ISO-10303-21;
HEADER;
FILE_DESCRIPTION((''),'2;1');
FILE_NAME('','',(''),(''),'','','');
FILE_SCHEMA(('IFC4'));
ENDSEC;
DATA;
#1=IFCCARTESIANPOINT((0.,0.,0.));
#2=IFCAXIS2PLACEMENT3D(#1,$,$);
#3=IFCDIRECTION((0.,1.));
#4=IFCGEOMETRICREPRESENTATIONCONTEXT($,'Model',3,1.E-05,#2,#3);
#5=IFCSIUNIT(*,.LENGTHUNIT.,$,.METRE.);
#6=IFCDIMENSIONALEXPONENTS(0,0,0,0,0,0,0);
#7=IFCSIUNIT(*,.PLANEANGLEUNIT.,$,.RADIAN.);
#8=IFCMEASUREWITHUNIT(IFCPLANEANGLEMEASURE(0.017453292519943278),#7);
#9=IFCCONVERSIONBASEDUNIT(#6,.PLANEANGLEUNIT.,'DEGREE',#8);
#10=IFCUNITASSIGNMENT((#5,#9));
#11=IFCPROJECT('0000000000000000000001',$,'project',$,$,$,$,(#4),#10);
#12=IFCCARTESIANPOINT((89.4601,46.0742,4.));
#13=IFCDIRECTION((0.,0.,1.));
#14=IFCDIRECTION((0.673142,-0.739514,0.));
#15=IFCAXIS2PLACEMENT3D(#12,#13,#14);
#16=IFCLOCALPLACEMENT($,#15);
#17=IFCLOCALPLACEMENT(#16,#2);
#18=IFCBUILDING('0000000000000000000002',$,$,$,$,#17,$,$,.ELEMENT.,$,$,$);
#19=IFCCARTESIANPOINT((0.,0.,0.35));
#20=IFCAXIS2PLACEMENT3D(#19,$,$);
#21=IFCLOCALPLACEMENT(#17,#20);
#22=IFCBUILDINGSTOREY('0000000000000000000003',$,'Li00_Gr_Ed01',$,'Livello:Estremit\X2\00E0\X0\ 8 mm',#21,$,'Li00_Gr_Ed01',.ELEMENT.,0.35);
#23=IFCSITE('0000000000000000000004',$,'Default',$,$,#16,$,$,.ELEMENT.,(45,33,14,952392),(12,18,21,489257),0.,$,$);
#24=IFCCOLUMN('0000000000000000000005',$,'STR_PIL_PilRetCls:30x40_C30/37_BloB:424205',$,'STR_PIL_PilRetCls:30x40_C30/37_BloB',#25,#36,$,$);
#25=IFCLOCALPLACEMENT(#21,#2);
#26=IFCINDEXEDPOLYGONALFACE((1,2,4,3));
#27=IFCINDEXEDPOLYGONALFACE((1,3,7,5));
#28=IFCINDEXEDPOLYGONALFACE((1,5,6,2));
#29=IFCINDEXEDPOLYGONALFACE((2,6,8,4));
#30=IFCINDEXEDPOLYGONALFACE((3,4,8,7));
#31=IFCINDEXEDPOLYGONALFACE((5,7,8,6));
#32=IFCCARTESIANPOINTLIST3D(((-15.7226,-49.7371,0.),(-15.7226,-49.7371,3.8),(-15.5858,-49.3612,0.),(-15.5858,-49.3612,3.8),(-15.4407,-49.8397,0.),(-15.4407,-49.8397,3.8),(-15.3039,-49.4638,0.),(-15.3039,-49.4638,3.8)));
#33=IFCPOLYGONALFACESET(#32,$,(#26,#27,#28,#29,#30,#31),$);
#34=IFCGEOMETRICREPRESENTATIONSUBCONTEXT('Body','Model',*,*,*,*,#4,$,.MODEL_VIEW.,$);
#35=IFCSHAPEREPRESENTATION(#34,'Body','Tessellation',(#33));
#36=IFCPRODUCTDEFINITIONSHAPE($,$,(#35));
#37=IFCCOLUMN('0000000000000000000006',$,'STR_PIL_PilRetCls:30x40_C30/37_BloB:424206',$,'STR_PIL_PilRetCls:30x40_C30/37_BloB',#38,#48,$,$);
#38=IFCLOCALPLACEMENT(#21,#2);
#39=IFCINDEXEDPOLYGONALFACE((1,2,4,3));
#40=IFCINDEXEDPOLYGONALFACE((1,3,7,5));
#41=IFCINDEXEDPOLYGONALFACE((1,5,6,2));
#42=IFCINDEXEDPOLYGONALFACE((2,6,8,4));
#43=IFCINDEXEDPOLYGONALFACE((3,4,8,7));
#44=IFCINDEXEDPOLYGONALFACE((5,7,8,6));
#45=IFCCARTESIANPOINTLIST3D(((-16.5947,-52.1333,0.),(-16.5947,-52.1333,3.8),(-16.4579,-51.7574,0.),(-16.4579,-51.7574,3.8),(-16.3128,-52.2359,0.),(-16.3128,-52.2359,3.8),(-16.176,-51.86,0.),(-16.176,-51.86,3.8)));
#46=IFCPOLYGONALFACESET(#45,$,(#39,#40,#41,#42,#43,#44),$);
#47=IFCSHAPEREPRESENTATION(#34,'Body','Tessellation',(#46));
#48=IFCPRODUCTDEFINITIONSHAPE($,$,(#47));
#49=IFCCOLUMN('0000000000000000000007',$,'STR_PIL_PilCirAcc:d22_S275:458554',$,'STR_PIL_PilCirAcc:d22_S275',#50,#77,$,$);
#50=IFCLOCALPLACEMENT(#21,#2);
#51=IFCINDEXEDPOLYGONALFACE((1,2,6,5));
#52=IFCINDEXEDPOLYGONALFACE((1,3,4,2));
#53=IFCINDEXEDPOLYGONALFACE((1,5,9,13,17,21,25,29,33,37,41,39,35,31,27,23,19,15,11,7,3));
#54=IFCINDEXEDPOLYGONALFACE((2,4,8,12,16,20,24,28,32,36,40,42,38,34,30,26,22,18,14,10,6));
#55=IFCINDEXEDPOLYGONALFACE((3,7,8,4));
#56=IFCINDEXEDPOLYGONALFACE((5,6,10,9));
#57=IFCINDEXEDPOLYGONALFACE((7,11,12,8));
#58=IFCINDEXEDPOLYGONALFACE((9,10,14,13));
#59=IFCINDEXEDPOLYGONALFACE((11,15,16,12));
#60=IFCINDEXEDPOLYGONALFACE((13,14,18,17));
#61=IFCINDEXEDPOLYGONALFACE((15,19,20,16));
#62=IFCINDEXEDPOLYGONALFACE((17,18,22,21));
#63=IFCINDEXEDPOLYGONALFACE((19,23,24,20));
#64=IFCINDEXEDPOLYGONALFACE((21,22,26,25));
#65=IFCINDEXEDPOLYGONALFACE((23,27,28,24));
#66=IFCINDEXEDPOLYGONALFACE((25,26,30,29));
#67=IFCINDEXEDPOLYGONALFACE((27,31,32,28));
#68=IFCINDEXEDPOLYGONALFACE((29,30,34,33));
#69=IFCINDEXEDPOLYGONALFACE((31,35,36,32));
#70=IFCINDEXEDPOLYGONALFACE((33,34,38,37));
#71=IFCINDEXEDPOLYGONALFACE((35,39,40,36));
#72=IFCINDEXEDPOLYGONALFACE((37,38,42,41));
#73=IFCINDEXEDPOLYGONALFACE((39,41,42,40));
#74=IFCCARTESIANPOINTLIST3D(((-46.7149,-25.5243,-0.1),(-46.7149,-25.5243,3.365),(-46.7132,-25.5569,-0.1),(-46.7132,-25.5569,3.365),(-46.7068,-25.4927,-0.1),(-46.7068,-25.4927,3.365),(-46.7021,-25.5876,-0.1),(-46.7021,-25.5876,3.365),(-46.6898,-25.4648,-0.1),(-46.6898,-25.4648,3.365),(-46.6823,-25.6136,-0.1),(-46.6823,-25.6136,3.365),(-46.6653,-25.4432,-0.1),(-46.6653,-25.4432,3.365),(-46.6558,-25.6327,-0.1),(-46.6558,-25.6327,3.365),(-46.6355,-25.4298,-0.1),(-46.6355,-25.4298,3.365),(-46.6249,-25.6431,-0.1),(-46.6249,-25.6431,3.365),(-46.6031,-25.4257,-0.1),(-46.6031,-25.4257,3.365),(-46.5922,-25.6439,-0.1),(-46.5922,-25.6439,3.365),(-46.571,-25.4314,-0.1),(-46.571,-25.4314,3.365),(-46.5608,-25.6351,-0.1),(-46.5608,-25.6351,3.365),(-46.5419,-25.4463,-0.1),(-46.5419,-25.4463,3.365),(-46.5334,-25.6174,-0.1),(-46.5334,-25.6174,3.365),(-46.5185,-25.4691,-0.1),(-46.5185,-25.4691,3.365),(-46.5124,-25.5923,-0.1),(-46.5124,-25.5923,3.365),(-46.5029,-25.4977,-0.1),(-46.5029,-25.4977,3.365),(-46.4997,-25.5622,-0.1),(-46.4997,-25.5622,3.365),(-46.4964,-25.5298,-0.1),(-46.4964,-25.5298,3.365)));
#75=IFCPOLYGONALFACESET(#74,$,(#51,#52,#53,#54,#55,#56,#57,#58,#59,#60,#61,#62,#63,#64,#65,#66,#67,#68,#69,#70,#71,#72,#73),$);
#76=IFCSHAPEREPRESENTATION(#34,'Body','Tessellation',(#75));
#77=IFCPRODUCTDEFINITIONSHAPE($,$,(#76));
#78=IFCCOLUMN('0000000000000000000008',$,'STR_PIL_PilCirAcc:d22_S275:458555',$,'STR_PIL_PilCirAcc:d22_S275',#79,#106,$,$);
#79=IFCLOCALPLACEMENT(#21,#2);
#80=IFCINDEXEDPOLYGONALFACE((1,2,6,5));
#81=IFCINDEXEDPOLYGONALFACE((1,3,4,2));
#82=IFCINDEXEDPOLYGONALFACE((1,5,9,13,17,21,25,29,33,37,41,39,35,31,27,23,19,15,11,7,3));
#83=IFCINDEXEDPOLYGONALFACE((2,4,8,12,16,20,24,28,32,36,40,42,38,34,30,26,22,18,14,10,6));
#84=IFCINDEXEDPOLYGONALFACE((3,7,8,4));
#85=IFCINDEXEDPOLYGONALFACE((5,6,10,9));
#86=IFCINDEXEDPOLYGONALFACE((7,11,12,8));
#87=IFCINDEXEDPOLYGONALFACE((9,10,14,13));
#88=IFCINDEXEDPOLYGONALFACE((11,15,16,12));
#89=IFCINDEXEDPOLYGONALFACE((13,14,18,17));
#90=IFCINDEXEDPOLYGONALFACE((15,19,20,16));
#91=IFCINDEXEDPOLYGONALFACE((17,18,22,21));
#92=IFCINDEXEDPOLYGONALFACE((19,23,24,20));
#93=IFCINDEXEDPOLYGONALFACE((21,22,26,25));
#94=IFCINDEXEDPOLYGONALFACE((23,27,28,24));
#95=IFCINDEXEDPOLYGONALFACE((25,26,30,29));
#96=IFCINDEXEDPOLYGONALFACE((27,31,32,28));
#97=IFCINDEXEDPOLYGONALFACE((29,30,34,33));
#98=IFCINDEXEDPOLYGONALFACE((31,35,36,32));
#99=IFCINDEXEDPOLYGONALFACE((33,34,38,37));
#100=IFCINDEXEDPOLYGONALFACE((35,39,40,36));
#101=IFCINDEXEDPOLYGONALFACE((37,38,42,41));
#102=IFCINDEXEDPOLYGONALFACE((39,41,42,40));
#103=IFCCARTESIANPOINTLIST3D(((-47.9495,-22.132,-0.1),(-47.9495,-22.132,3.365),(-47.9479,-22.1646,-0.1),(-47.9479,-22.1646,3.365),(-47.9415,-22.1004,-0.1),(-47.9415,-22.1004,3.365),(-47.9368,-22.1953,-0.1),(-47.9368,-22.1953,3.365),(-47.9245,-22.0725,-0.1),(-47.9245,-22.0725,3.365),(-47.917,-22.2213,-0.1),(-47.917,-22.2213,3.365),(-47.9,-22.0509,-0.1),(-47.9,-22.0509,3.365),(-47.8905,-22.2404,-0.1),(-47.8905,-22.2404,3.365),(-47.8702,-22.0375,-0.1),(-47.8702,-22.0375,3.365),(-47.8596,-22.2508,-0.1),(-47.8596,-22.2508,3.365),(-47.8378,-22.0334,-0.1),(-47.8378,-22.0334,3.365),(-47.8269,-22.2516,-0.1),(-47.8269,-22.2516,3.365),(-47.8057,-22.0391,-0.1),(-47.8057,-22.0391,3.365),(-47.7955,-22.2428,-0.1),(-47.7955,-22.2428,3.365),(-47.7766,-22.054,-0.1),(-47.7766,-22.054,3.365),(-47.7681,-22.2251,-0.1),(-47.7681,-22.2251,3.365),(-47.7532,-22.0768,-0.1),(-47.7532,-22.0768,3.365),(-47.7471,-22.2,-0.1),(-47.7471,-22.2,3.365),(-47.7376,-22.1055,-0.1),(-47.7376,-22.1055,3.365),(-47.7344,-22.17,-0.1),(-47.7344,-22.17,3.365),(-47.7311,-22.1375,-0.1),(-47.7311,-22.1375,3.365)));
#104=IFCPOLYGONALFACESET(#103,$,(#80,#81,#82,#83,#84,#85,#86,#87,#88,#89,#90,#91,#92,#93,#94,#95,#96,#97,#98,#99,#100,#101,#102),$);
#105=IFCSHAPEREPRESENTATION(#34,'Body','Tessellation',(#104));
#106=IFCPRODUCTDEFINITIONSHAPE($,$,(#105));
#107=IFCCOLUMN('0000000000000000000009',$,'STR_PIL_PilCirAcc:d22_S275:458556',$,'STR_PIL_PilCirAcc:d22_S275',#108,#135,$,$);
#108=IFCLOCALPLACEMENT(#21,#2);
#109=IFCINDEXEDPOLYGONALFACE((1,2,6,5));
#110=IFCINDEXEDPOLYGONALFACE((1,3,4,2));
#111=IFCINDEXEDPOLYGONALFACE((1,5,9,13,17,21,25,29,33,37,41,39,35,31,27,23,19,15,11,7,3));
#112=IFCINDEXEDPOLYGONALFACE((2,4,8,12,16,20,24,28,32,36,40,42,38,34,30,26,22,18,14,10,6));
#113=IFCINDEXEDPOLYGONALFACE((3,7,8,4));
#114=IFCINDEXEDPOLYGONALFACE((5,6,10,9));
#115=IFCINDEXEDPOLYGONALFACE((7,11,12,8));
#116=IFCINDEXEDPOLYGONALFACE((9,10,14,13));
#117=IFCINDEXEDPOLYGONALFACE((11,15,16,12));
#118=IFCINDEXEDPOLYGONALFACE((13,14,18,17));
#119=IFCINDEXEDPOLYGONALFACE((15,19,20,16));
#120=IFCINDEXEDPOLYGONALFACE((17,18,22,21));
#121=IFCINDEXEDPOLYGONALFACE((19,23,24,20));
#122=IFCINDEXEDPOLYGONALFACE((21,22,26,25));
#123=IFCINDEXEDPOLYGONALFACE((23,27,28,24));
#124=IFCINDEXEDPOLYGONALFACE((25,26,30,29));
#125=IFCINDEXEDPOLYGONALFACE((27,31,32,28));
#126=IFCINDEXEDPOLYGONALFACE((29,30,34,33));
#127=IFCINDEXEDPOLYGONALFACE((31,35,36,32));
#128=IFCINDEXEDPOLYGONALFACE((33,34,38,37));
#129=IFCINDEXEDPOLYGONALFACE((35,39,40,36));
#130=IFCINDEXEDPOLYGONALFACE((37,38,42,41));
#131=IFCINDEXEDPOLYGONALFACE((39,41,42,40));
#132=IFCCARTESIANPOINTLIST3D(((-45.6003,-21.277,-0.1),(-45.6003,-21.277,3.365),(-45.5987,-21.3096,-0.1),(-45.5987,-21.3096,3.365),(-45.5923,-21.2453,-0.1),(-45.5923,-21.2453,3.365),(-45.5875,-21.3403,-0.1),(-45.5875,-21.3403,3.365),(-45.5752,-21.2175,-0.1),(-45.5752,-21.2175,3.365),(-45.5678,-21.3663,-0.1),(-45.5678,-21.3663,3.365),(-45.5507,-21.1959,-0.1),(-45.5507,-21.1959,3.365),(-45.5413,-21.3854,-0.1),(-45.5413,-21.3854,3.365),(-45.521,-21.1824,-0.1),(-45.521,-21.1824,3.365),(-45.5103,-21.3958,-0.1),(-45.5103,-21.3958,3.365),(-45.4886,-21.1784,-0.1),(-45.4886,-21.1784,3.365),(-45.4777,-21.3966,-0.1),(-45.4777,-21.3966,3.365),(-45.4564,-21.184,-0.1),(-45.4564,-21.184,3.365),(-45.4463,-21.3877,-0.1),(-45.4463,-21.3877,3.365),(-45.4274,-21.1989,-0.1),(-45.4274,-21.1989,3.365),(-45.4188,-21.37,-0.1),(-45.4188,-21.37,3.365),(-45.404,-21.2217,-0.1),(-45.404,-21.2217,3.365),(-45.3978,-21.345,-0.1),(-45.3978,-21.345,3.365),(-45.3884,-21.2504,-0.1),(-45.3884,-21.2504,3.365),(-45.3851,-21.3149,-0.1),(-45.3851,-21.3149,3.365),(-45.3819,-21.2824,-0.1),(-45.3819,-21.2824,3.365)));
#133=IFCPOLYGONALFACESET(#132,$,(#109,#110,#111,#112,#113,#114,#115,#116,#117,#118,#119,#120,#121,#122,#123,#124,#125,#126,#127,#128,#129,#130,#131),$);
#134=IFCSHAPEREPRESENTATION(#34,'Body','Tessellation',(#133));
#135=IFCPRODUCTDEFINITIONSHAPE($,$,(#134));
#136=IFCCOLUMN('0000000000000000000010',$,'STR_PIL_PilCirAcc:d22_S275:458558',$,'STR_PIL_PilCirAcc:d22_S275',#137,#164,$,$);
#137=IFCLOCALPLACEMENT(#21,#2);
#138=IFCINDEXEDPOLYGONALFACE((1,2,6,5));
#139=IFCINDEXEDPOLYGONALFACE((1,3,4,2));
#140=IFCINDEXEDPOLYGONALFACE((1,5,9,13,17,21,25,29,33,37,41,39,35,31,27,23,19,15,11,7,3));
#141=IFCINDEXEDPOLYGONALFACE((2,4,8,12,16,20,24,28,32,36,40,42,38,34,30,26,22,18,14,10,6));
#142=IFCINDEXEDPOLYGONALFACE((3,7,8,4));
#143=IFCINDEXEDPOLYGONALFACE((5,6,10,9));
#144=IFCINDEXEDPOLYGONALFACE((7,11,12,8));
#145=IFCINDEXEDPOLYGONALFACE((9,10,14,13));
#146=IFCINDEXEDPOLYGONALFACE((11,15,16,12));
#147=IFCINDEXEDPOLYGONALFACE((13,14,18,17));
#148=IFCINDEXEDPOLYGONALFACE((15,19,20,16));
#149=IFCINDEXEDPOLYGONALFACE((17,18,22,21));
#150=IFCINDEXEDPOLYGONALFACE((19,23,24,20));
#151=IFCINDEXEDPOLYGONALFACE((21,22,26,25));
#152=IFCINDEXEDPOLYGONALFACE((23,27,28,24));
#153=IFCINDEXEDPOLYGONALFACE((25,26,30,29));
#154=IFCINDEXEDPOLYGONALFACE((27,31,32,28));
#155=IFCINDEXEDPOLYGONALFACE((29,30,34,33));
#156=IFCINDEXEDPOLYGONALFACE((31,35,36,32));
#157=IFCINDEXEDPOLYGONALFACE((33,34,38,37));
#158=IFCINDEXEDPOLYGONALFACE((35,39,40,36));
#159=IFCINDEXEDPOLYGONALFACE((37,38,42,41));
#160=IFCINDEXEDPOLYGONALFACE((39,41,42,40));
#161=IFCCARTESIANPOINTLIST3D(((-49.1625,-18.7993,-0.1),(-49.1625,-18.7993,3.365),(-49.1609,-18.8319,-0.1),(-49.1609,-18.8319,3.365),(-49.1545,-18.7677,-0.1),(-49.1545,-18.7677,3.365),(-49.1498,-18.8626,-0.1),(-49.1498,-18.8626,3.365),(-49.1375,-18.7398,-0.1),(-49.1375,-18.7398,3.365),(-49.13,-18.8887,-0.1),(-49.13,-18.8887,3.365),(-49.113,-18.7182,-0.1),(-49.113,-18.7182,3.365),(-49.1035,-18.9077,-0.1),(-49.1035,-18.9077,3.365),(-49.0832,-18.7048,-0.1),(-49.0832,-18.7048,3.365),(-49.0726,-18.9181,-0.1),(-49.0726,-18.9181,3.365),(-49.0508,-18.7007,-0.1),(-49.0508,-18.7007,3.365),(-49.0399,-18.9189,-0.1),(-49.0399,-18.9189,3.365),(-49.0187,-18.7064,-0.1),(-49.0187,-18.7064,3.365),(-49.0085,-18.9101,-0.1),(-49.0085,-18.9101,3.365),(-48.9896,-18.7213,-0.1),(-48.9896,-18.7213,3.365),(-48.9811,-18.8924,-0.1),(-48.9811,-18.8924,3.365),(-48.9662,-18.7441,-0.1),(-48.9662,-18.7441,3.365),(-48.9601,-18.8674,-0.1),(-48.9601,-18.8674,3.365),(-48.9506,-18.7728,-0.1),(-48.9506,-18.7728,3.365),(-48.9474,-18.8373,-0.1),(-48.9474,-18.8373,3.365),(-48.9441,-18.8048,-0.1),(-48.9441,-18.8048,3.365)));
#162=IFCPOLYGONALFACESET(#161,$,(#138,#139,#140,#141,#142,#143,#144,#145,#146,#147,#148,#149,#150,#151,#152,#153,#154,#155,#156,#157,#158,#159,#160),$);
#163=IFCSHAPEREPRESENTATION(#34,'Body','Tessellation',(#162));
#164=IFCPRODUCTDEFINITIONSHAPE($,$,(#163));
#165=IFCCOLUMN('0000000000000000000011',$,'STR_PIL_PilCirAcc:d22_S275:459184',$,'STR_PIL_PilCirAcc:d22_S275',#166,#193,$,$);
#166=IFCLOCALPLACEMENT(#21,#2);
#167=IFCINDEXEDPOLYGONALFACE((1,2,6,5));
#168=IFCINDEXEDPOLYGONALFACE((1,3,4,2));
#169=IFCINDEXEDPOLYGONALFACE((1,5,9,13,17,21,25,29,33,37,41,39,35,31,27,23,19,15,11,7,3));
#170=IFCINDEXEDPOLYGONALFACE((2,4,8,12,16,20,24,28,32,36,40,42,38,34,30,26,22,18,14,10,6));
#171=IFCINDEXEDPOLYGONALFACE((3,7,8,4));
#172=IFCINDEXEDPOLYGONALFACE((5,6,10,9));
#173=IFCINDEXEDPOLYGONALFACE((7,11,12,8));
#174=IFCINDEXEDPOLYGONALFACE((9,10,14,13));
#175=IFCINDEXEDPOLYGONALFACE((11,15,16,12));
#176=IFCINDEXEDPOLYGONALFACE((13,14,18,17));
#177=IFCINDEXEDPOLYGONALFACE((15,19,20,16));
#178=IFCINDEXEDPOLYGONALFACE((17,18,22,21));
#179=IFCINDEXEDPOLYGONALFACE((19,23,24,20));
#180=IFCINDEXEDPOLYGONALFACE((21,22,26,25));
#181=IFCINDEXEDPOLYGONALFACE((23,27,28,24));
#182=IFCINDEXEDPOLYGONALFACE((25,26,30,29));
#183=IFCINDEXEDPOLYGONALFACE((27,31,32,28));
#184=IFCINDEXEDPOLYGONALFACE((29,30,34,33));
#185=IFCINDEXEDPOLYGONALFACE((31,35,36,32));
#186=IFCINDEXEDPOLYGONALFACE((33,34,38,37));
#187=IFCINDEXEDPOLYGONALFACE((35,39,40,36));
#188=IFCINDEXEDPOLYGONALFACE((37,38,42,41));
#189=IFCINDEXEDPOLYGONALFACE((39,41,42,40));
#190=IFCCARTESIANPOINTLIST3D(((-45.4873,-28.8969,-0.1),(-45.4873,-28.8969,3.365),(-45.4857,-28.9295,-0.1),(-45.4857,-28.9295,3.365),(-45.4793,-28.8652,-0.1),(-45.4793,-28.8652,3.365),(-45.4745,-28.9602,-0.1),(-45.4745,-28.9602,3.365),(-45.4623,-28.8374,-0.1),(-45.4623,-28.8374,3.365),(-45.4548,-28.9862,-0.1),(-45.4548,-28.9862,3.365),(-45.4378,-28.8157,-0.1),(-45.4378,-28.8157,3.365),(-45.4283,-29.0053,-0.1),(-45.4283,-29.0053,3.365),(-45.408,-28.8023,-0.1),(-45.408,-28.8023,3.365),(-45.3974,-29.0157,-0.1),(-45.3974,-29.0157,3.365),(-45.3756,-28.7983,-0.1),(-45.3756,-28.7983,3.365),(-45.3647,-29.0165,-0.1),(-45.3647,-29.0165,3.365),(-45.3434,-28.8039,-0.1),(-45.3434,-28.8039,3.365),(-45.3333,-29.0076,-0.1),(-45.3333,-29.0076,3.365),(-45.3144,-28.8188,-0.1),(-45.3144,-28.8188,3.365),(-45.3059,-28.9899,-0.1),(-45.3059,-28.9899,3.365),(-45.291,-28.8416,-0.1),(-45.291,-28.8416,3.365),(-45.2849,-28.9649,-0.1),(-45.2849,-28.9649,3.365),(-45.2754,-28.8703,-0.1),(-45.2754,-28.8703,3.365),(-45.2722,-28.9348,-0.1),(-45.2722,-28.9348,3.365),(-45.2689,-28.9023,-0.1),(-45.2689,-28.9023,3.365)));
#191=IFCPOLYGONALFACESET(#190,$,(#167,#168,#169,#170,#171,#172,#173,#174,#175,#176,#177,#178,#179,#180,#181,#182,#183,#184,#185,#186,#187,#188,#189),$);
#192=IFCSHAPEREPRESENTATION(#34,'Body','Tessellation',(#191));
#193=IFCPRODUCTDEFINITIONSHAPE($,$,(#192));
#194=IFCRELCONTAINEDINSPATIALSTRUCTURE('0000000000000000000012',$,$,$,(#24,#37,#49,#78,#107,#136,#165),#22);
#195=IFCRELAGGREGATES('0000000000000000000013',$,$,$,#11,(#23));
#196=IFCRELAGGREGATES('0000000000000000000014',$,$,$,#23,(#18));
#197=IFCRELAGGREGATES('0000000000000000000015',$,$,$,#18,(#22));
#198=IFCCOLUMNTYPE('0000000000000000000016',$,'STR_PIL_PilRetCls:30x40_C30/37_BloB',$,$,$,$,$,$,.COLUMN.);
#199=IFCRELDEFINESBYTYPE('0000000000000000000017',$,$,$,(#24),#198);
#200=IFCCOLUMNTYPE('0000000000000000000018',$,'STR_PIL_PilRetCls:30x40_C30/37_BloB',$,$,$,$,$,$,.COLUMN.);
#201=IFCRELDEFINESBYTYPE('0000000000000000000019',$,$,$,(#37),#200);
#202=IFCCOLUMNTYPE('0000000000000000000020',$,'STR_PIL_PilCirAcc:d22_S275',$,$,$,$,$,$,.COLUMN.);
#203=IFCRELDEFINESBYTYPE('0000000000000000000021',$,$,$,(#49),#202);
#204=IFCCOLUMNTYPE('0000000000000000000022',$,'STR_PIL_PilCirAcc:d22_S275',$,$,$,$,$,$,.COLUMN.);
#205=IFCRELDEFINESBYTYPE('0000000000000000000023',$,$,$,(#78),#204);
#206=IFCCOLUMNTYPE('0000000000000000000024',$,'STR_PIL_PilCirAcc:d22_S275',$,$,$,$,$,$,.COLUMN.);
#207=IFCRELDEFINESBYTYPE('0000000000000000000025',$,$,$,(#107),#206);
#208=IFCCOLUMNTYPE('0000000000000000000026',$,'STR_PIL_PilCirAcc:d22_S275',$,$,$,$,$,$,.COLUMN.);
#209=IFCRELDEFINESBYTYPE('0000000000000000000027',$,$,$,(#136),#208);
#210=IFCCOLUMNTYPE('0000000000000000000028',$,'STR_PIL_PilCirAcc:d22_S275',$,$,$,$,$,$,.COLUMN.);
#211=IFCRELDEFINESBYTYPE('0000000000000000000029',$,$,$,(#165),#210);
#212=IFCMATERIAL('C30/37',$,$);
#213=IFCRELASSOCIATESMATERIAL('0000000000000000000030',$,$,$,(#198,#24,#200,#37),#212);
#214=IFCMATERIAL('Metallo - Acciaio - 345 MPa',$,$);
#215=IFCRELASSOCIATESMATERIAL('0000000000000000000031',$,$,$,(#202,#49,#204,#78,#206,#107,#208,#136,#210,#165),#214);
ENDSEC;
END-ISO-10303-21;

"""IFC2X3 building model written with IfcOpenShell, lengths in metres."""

from ifc_helpers import new_model, entity, si_unit, converted_unit, direction, frame, frame_2d, origin, origin_2d_with_axis, place, context, subcontext, project, spatial, rectangle, circle, extrude, source, transform, mapped, material, type_object, type_shapes, element, save


model = new_model("IFC2X3")

# Units and contexts
model_context = context("Model", 3, precision=1e-05, world=origin(), true_north=direction((0.0, 1.0)))
body_context = subcontext(model_context, "Body", "Model", "MODEL_VIEW")
ifc_project = project(units=[si_unit("LENGTHUNIT", "METRE"), converted_unit("PLANEANGLEUNIT", "DEGREE", entity("IfcPlaneAngleMeasure", 0.017453292519943278), si_unit("PLANEANGLEUNIT", "RADIAN"), dimensions=[0, 0, 0, 0, 0, 0, 0])], contexts=[model_context])

# Site, building, storey
site_placement = place(None, frame((89.4601, 46.0742, 4.0), z_axis=(0.0, 0.0, 1.0), x_axis=(0.673142, -0.739514, 0.0)))
site = spatial("IfcSite", under=ifc_project, at=site_placement, Name="Default", CompositionType="ELEMENT", RefLatitude=(45, 33, 14, 952392), RefLongitude=(12, 18, 21, 489257), RefElevation=0.0)
building_placement = place(site_placement, origin())
building = spatial("IfcBuilding", under=site, at=building_placement, CompositionType="ELEMENT")
storey_placement = place(building_placement, frame((0.0, 0.0, 0.35)))
storey = spatial("IfcBuildingStorey", under=building, at=storey_placement, Name="Li00_Gr_Ed01", ObjectType="Livello:Estremità 8 mm", LongName="Li00_Gr_Ed01", CompositionType="ELEMENT", Elevation=0.35)

# Columns
ifc_material_1 = material(Name="C30/37")
column_type_1 = type_object("IfcColumnType", Name="STR_PIL_PilRetCls:30x40_C30/37_BloB", PredefinedType="COLUMN", material=ifc_material_1)
shared_shape_1 = source(origin(), body_context, "Body", "SweptSolid", [
    extrude(rectangle(XDim=0.3, YDim=0.4, at=frame_2d((0.0, 0.0), x_axis=(1.0, 0.0))), frame((-15.5132, -49.6005, 0.35), z_axis=(0.0, 0.0, 1.0), x_axis=(0.939693, -0.34202, 0.0)), (0.0, 0.0, 1.0), 3.8),
])
type_shapes(column_type_1, [shared_shape_1])
column_1_placement = place(storey_placement, frame((0.0, 0.0, -0.35)))
element("IfcColumn", 1, at=column_1_placement, inside=storey, type_object=column_type_1, material=ifc_material_1, Name="STR_PIL_PilRetCls:30x40_C30/37_BloB:424205", ObjectType="STR_PIL_PilRetCls:30x40_C30/37_BloB", context=body_context, shape_type="MappedRepresentation", body=[
    mapped(shared_shape_1, transform((0.0, 0.0, 0.0), scale=1.0)),
])
column_type_2 = type_object("IfcColumnType", Name="STR_PIL_PilRetCls:30x40_C30/37_BloB", PredefinedType="COLUMN", material=ifc_material_1)
shared_shape_2 = source(origin(), body_context, "Body", "SweptSolid", [
    extrude(rectangle(XDim=0.3, YDim=0.4, at=frame_2d((0.0, 0.0), x_axis=(1.0, 0.0))), frame((-16.3854, -51.9967, 0.35), z_axis=(0.0, 0.0, 1.0), x_axis=(0.939693, -0.34202, 0.0)), (0.0, 0.0, 1.0), 3.8),
])
type_shapes(column_type_2, [shared_shape_2])
column_2_placement = place(storey_placement, frame((0.0, 0.0, -0.35)))
element("IfcColumn", 2, at=column_2_placement, inside=storey, type_object=column_type_2, material=ifc_material_1, Name="STR_PIL_PilRetCls:30x40_C30/37_BloB:424206", ObjectType="STR_PIL_PilRetCls:30x40_C30/37_BloB", context=body_context, shape_type="MappedRepresentation", body=[
    mapped(shared_shape_2, transform((0.0, 0.0, 0.0), scale=1.0)),
])
ifc_material_2 = material(Name="Metallo - Acciaio - 345 MPa")
column_type_3 = type_object("IfcColumnType", Name="STR_PIL_PilCirAcc:d22_S275", PredefinedType="COLUMN", material=ifc_material_2)
shared_shape_3 = source(origin(), body_context, "Body", "SweptSolid", [
    extrude(circle(Radius=0.1096, at=origin_2d_with_axis()), frame((-46.6058, -25.5352, 0.25), z_axis=(0.0, 0.0, 1.0), x_axis=(0.939693, 0.34202, 0.0)), (0.0, 0.0, 1.0), 3.465),
])
type_shapes(column_type_3, [shared_shape_3])
column_3_placement = place(storey_placement, frame((0.0, 0.0, -0.35)))
element("IfcColumn", 3, at=column_3_placement, inside=storey, type_object=column_type_3, material=ifc_material_2, Name="STR_PIL_PilCirAcc:d22_S275:458554", ObjectType="STR_PIL_PilCirAcc:d22_S275", context=body_context, shape_type="MappedRepresentation", body=[
    mapped(shared_shape_3, transform((0.0, 0.0, 0.0), scale=1.0)),
])
column_type_4 = type_object("IfcColumnType", Name="STR_PIL_PilCirAcc:d22_S275", PredefinedType="COLUMN", material=ifc_material_2)
shared_shape_4 = source(origin(), body_context, "Body", "SweptSolid", [
    extrude(circle(Radius=0.1096, at=origin_2d_with_axis()), frame((-47.8405, -22.1429, 0.25), z_axis=(0.0, 0.0, 1.0), x_axis=(0.939693, 0.34202, 0.0)), (0.0, 0.0, 1.0), 3.465),
])
type_shapes(column_type_4, [shared_shape_4])
column_4_placement = place(storey_placement, frame((0.0, 0.0, -0.35)))
element("IfcColumn", 4, at=column_4_placement, inside=storey, type_object=column_type_4, material=ifc_material_2, Name="STR_PIL_PilCirAcc:d22_S275:458555", ObjectType="STR_PIL_PilCirAcc:d22_S275", context=body_context, shape_type="MappedRepresentation", body=[
    mapped(shared_shape_4, transform((0.0, 0.0, 0.0), scale=1.0)),
])
column_type_5 = type_object("IfcColumnType", Name="STR_PIL_PilCirAcc:d22_S275", PredefinedType="COLUMN", material=ifc_material_2)
shared_shape_5 = source(origin(), body_context, "Body", "SweptSolid", [
    extrude(circle(Radius=0.1096, at=origin_2d_with_axis()), frame((-45.4913, -21.2879, 0.25), z_axis=(0.0, 0.0, 1.0), x_axis=(0.939693, 0.34202, 0.0)), (0.0, 0.0, 1.0), 3.465),
])
type_shapes(column_type_5, [shared_shape_5])
column_5_placement = place(storey_placement, frame((0.0, 0.0, -0.35)))
element("IfcColumn", 5, at=column_5_placement, inside=storey, type_object=column_type_5, material=ifc_material_2, Name="STR_PIL_PilCirAcc:d22_S275:458556", ObjectType="STR_PIL_PilCirAcc:d22_S275", context=body_context, shape_type="MappedRepresentation", body=[
    mapped(shared_shape_5, transform((0.0, 0.0, 0.0), scale=1.0)),
])
column_type_6 = type_object("IfcColumnType", Name="STR_PIL_PilCirAcc:d22_S275", PredefinedType="COLUMN", material=ifc_material_2)
shared_shape_6 = source(origin(), body_context, "Body", "SweptSolid", [
    extrude(circle(Radius=0.1096, at=origin_2d_with_axis()), frame((-49.0535, -18.8102, 0.25), z_axis=(0.0, 0.0, 1.0), x_axis=(0.939693, 0.34202, 0.0)), (0.0, 0.0, 1.0), 3.465),
])
type_shapes(column_type_6, [shared_shape_6])
column_6_placement = place(storey_placement, frame((0.0, 0.0, -0.35)))
element("IfcColumn", 6, at=column_6_placement, inside=storey, type_object=column_type_6, material=ifc_material_2, Name="STR_PIL_PilCirAcc:d22_S275:458558", ObjectType="STR_PIL_PilCirAcc:d22_S275", context=body_context, shape_type="MappedRepresentation", body=[
    mapped(shared_shape_6, transform((0.0, 0.0, 0.0), scale=1.0)),
])
column_type_7 = type_object("IfcColumnType", Name="STR_PIL_PilCirAcc:d22_S275", PredefinedType="COLUMN", material=ifc_material_2)
shared_shape_7 = source(origin(), body_context, "Body", "SweptSolid", [
    extrude(circle(Radius=0.1096, at=origin_2d_with_axis()), frame((-45.3783, -28.9078, 0.25), z_axis=(0.0, 0.0, 1.0), x_axis=(0.939693, 0.34202, 0.0)), (0.0, 0.0, 1.0), 3.465),
])
type_shapes(column_type_7, [shared_shape_7])
column_7_placement = place(storey_placement, frame((0.0, 0.0, -0.35)))
element("IfcColumn", 7, at=column_7_placement, inside=storey, type_object=column_type_7, material=ifc_material_2, Name="STR_PIL_PilCirAcc:d22_S275:459184", ObjectType="STR_PIL_PilCirAcc:d22_S275", context=body_context, shape_type="MappedRepresentation", body=[
    mapped(shared_shape_7, transform((0.0, 0.0, 0.0), scale=1.0)),
])

save(model, "model.ifc")
